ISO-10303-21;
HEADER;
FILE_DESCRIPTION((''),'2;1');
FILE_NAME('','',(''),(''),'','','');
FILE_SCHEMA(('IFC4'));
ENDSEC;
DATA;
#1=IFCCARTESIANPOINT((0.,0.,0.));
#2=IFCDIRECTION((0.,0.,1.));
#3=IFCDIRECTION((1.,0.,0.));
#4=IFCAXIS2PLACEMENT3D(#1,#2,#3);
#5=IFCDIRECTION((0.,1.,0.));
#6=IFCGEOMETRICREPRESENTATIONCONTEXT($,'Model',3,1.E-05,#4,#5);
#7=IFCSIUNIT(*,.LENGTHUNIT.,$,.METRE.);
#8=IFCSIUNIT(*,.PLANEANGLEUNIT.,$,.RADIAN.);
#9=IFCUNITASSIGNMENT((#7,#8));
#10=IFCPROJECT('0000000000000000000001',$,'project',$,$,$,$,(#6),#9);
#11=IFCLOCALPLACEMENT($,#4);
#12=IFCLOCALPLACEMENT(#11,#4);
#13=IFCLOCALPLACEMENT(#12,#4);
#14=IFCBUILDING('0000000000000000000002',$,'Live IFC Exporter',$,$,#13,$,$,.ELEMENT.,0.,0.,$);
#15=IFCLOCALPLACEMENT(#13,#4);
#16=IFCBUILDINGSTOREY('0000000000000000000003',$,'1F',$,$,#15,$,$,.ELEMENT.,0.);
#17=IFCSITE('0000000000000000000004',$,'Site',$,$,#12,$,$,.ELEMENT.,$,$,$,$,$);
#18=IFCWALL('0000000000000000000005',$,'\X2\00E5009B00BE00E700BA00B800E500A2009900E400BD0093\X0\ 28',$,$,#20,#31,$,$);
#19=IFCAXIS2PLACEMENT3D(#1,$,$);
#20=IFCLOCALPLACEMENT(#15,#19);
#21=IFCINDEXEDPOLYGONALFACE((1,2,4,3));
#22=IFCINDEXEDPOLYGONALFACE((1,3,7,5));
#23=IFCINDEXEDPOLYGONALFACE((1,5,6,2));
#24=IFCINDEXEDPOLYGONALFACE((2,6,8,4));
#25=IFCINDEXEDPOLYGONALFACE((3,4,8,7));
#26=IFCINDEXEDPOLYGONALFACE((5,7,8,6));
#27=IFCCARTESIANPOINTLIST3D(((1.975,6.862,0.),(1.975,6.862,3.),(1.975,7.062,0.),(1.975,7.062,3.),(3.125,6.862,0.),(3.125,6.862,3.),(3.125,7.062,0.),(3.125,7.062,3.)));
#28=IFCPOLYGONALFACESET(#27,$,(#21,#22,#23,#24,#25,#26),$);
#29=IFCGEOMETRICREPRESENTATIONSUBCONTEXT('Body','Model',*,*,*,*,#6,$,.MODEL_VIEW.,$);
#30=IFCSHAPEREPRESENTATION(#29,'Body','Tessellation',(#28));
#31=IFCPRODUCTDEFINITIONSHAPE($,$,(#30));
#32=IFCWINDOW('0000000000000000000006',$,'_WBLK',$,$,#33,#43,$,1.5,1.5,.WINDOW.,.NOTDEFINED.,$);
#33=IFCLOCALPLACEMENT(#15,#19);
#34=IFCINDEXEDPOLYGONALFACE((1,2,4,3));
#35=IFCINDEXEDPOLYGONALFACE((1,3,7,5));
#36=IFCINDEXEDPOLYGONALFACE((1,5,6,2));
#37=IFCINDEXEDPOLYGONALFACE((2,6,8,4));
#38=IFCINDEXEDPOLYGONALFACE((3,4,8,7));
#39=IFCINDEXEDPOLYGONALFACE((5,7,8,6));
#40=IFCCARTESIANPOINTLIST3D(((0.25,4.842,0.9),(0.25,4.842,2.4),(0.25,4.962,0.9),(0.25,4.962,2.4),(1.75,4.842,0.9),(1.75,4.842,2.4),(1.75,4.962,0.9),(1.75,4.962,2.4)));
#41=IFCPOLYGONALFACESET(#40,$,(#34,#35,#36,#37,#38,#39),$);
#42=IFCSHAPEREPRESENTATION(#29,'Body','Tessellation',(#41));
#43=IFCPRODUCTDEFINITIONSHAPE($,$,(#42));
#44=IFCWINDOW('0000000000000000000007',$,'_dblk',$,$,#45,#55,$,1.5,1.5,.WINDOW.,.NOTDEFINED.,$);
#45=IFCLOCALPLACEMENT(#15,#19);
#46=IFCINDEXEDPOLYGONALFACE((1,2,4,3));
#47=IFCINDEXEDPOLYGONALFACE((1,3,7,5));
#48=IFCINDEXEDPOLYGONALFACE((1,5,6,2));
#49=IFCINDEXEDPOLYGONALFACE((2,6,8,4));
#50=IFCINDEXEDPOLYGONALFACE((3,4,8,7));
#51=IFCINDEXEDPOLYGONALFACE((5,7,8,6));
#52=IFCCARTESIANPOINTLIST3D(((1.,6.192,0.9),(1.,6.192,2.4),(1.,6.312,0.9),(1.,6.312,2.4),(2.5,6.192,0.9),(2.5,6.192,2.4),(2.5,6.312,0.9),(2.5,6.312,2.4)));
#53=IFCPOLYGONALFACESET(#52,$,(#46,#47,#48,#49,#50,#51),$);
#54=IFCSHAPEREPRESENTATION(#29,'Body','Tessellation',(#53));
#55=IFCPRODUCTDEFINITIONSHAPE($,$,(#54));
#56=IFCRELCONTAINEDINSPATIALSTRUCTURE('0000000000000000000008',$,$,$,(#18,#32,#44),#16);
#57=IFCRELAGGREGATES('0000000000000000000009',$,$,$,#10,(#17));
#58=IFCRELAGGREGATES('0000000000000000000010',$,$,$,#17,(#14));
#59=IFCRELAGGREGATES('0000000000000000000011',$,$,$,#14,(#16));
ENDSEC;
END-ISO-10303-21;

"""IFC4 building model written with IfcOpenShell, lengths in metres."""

from ifc_helpers import new_model, si_unit, direction, frame, frame_2d, origin_with_axes, place, context, subcontext, project, spatial, rectangle, extrude, element, save


model = new_model("IFC4")

# Units and contexts
model_context = context("Model", 3, precision=1e-05, world=origin_with_axes(), true_north=direction((0.0, 1.0, 0.0)))
body_context = subcontext(model_context, "Body", "Model", "MODEL_VIEW")
ifc_project = project(units=[si_unit("LENGTHUNIT", "METRE"), si_unit("PLANEANGLEUNIT", "RADIAN")], contexts=[model_context])

# Site, building, storey
placement = place(None, origin_with_axes())
site_placement = place(placement, origin_with_axes())
site = spatial("IfcSite", under=ifc_project, at=site_placement, Name="Site", CompositionType="ELEMENT")
building_placement = place(site_placement, origin_with_axes())
building = spatial("IfcBuilding", under=site, at=building_placement, Name="Live IFC Exporter", CompositionType="ELEMENT", ElevationOfRefHeight=0.0, ElevationOfTerrain=0.0)
storey_placement = place(building_placement, origin_with_axes())
storey = spatial("IfcBuildingStorey", under=building, at=storey_placement, Name="1F", CompositionType="ELEMENT", Elevation=0.0)

# Wall
wall_1_placement = place(storey_placement, frame((2.55, 6.962, 0.0), z_axis=(0.0, 0.0, 1.0), x_axis=(-1.0, 0.0, 0.0)))
element("IfcWall", 1, at=wall_1_placement, inside=storey, Name="å\u009b¾çº¸å¢\u0099ä½\u0093 28", context=body_context, shape_type="SweptSolid", body=[
    extrude(rectangle(XDim=1.15, YDim=0.2, at=frame_2d((0.0, 0.0), x_axis=(1.0, 0.0, 0.0))), frame((0.0, 0.0, 0.0), z_axis=(0.0, 0.0, 1.0)), (0.0, 0.0, 1.0), 3.0),
])

# Windows
for number, where, z_axis, x_axis, name in (
    (2, (1.0, 4.902, 0.9), (0.0, 0.0, 1.0), (1.0, 0.0, 0.0), "_WBLK"),
    (3, (1.75, 6.252, 0.9), (0.0, 0.0, 1.0), (1.0, 0.0, 0.0), "_dblk"),
):
    element("IfcWindow", number, at=place(storey_placement, frame(where, z_axis=z_axis, x_axis=x_axis)), inside=storey, Name=name, OverallHeight=1.5, OverallWidth=1.5, PartitioningType="NOTDEFINED", PredefinedType="WINDOW", context=body_context, shape_type="SweptSolid", body=[
        extrude(rectangle(XDim=1.5, YDim=0.12, at=frame_2d((0.0, 0.0), x_axis=(1.0, 0.0, 0.0))), frame((0.0, 0.0, 0.0), z_axis=(0.0, 0.0, 1.0)), (0.0, 0.0, 1.0), 1.5),
    ])

save(model, "model.ifc")
